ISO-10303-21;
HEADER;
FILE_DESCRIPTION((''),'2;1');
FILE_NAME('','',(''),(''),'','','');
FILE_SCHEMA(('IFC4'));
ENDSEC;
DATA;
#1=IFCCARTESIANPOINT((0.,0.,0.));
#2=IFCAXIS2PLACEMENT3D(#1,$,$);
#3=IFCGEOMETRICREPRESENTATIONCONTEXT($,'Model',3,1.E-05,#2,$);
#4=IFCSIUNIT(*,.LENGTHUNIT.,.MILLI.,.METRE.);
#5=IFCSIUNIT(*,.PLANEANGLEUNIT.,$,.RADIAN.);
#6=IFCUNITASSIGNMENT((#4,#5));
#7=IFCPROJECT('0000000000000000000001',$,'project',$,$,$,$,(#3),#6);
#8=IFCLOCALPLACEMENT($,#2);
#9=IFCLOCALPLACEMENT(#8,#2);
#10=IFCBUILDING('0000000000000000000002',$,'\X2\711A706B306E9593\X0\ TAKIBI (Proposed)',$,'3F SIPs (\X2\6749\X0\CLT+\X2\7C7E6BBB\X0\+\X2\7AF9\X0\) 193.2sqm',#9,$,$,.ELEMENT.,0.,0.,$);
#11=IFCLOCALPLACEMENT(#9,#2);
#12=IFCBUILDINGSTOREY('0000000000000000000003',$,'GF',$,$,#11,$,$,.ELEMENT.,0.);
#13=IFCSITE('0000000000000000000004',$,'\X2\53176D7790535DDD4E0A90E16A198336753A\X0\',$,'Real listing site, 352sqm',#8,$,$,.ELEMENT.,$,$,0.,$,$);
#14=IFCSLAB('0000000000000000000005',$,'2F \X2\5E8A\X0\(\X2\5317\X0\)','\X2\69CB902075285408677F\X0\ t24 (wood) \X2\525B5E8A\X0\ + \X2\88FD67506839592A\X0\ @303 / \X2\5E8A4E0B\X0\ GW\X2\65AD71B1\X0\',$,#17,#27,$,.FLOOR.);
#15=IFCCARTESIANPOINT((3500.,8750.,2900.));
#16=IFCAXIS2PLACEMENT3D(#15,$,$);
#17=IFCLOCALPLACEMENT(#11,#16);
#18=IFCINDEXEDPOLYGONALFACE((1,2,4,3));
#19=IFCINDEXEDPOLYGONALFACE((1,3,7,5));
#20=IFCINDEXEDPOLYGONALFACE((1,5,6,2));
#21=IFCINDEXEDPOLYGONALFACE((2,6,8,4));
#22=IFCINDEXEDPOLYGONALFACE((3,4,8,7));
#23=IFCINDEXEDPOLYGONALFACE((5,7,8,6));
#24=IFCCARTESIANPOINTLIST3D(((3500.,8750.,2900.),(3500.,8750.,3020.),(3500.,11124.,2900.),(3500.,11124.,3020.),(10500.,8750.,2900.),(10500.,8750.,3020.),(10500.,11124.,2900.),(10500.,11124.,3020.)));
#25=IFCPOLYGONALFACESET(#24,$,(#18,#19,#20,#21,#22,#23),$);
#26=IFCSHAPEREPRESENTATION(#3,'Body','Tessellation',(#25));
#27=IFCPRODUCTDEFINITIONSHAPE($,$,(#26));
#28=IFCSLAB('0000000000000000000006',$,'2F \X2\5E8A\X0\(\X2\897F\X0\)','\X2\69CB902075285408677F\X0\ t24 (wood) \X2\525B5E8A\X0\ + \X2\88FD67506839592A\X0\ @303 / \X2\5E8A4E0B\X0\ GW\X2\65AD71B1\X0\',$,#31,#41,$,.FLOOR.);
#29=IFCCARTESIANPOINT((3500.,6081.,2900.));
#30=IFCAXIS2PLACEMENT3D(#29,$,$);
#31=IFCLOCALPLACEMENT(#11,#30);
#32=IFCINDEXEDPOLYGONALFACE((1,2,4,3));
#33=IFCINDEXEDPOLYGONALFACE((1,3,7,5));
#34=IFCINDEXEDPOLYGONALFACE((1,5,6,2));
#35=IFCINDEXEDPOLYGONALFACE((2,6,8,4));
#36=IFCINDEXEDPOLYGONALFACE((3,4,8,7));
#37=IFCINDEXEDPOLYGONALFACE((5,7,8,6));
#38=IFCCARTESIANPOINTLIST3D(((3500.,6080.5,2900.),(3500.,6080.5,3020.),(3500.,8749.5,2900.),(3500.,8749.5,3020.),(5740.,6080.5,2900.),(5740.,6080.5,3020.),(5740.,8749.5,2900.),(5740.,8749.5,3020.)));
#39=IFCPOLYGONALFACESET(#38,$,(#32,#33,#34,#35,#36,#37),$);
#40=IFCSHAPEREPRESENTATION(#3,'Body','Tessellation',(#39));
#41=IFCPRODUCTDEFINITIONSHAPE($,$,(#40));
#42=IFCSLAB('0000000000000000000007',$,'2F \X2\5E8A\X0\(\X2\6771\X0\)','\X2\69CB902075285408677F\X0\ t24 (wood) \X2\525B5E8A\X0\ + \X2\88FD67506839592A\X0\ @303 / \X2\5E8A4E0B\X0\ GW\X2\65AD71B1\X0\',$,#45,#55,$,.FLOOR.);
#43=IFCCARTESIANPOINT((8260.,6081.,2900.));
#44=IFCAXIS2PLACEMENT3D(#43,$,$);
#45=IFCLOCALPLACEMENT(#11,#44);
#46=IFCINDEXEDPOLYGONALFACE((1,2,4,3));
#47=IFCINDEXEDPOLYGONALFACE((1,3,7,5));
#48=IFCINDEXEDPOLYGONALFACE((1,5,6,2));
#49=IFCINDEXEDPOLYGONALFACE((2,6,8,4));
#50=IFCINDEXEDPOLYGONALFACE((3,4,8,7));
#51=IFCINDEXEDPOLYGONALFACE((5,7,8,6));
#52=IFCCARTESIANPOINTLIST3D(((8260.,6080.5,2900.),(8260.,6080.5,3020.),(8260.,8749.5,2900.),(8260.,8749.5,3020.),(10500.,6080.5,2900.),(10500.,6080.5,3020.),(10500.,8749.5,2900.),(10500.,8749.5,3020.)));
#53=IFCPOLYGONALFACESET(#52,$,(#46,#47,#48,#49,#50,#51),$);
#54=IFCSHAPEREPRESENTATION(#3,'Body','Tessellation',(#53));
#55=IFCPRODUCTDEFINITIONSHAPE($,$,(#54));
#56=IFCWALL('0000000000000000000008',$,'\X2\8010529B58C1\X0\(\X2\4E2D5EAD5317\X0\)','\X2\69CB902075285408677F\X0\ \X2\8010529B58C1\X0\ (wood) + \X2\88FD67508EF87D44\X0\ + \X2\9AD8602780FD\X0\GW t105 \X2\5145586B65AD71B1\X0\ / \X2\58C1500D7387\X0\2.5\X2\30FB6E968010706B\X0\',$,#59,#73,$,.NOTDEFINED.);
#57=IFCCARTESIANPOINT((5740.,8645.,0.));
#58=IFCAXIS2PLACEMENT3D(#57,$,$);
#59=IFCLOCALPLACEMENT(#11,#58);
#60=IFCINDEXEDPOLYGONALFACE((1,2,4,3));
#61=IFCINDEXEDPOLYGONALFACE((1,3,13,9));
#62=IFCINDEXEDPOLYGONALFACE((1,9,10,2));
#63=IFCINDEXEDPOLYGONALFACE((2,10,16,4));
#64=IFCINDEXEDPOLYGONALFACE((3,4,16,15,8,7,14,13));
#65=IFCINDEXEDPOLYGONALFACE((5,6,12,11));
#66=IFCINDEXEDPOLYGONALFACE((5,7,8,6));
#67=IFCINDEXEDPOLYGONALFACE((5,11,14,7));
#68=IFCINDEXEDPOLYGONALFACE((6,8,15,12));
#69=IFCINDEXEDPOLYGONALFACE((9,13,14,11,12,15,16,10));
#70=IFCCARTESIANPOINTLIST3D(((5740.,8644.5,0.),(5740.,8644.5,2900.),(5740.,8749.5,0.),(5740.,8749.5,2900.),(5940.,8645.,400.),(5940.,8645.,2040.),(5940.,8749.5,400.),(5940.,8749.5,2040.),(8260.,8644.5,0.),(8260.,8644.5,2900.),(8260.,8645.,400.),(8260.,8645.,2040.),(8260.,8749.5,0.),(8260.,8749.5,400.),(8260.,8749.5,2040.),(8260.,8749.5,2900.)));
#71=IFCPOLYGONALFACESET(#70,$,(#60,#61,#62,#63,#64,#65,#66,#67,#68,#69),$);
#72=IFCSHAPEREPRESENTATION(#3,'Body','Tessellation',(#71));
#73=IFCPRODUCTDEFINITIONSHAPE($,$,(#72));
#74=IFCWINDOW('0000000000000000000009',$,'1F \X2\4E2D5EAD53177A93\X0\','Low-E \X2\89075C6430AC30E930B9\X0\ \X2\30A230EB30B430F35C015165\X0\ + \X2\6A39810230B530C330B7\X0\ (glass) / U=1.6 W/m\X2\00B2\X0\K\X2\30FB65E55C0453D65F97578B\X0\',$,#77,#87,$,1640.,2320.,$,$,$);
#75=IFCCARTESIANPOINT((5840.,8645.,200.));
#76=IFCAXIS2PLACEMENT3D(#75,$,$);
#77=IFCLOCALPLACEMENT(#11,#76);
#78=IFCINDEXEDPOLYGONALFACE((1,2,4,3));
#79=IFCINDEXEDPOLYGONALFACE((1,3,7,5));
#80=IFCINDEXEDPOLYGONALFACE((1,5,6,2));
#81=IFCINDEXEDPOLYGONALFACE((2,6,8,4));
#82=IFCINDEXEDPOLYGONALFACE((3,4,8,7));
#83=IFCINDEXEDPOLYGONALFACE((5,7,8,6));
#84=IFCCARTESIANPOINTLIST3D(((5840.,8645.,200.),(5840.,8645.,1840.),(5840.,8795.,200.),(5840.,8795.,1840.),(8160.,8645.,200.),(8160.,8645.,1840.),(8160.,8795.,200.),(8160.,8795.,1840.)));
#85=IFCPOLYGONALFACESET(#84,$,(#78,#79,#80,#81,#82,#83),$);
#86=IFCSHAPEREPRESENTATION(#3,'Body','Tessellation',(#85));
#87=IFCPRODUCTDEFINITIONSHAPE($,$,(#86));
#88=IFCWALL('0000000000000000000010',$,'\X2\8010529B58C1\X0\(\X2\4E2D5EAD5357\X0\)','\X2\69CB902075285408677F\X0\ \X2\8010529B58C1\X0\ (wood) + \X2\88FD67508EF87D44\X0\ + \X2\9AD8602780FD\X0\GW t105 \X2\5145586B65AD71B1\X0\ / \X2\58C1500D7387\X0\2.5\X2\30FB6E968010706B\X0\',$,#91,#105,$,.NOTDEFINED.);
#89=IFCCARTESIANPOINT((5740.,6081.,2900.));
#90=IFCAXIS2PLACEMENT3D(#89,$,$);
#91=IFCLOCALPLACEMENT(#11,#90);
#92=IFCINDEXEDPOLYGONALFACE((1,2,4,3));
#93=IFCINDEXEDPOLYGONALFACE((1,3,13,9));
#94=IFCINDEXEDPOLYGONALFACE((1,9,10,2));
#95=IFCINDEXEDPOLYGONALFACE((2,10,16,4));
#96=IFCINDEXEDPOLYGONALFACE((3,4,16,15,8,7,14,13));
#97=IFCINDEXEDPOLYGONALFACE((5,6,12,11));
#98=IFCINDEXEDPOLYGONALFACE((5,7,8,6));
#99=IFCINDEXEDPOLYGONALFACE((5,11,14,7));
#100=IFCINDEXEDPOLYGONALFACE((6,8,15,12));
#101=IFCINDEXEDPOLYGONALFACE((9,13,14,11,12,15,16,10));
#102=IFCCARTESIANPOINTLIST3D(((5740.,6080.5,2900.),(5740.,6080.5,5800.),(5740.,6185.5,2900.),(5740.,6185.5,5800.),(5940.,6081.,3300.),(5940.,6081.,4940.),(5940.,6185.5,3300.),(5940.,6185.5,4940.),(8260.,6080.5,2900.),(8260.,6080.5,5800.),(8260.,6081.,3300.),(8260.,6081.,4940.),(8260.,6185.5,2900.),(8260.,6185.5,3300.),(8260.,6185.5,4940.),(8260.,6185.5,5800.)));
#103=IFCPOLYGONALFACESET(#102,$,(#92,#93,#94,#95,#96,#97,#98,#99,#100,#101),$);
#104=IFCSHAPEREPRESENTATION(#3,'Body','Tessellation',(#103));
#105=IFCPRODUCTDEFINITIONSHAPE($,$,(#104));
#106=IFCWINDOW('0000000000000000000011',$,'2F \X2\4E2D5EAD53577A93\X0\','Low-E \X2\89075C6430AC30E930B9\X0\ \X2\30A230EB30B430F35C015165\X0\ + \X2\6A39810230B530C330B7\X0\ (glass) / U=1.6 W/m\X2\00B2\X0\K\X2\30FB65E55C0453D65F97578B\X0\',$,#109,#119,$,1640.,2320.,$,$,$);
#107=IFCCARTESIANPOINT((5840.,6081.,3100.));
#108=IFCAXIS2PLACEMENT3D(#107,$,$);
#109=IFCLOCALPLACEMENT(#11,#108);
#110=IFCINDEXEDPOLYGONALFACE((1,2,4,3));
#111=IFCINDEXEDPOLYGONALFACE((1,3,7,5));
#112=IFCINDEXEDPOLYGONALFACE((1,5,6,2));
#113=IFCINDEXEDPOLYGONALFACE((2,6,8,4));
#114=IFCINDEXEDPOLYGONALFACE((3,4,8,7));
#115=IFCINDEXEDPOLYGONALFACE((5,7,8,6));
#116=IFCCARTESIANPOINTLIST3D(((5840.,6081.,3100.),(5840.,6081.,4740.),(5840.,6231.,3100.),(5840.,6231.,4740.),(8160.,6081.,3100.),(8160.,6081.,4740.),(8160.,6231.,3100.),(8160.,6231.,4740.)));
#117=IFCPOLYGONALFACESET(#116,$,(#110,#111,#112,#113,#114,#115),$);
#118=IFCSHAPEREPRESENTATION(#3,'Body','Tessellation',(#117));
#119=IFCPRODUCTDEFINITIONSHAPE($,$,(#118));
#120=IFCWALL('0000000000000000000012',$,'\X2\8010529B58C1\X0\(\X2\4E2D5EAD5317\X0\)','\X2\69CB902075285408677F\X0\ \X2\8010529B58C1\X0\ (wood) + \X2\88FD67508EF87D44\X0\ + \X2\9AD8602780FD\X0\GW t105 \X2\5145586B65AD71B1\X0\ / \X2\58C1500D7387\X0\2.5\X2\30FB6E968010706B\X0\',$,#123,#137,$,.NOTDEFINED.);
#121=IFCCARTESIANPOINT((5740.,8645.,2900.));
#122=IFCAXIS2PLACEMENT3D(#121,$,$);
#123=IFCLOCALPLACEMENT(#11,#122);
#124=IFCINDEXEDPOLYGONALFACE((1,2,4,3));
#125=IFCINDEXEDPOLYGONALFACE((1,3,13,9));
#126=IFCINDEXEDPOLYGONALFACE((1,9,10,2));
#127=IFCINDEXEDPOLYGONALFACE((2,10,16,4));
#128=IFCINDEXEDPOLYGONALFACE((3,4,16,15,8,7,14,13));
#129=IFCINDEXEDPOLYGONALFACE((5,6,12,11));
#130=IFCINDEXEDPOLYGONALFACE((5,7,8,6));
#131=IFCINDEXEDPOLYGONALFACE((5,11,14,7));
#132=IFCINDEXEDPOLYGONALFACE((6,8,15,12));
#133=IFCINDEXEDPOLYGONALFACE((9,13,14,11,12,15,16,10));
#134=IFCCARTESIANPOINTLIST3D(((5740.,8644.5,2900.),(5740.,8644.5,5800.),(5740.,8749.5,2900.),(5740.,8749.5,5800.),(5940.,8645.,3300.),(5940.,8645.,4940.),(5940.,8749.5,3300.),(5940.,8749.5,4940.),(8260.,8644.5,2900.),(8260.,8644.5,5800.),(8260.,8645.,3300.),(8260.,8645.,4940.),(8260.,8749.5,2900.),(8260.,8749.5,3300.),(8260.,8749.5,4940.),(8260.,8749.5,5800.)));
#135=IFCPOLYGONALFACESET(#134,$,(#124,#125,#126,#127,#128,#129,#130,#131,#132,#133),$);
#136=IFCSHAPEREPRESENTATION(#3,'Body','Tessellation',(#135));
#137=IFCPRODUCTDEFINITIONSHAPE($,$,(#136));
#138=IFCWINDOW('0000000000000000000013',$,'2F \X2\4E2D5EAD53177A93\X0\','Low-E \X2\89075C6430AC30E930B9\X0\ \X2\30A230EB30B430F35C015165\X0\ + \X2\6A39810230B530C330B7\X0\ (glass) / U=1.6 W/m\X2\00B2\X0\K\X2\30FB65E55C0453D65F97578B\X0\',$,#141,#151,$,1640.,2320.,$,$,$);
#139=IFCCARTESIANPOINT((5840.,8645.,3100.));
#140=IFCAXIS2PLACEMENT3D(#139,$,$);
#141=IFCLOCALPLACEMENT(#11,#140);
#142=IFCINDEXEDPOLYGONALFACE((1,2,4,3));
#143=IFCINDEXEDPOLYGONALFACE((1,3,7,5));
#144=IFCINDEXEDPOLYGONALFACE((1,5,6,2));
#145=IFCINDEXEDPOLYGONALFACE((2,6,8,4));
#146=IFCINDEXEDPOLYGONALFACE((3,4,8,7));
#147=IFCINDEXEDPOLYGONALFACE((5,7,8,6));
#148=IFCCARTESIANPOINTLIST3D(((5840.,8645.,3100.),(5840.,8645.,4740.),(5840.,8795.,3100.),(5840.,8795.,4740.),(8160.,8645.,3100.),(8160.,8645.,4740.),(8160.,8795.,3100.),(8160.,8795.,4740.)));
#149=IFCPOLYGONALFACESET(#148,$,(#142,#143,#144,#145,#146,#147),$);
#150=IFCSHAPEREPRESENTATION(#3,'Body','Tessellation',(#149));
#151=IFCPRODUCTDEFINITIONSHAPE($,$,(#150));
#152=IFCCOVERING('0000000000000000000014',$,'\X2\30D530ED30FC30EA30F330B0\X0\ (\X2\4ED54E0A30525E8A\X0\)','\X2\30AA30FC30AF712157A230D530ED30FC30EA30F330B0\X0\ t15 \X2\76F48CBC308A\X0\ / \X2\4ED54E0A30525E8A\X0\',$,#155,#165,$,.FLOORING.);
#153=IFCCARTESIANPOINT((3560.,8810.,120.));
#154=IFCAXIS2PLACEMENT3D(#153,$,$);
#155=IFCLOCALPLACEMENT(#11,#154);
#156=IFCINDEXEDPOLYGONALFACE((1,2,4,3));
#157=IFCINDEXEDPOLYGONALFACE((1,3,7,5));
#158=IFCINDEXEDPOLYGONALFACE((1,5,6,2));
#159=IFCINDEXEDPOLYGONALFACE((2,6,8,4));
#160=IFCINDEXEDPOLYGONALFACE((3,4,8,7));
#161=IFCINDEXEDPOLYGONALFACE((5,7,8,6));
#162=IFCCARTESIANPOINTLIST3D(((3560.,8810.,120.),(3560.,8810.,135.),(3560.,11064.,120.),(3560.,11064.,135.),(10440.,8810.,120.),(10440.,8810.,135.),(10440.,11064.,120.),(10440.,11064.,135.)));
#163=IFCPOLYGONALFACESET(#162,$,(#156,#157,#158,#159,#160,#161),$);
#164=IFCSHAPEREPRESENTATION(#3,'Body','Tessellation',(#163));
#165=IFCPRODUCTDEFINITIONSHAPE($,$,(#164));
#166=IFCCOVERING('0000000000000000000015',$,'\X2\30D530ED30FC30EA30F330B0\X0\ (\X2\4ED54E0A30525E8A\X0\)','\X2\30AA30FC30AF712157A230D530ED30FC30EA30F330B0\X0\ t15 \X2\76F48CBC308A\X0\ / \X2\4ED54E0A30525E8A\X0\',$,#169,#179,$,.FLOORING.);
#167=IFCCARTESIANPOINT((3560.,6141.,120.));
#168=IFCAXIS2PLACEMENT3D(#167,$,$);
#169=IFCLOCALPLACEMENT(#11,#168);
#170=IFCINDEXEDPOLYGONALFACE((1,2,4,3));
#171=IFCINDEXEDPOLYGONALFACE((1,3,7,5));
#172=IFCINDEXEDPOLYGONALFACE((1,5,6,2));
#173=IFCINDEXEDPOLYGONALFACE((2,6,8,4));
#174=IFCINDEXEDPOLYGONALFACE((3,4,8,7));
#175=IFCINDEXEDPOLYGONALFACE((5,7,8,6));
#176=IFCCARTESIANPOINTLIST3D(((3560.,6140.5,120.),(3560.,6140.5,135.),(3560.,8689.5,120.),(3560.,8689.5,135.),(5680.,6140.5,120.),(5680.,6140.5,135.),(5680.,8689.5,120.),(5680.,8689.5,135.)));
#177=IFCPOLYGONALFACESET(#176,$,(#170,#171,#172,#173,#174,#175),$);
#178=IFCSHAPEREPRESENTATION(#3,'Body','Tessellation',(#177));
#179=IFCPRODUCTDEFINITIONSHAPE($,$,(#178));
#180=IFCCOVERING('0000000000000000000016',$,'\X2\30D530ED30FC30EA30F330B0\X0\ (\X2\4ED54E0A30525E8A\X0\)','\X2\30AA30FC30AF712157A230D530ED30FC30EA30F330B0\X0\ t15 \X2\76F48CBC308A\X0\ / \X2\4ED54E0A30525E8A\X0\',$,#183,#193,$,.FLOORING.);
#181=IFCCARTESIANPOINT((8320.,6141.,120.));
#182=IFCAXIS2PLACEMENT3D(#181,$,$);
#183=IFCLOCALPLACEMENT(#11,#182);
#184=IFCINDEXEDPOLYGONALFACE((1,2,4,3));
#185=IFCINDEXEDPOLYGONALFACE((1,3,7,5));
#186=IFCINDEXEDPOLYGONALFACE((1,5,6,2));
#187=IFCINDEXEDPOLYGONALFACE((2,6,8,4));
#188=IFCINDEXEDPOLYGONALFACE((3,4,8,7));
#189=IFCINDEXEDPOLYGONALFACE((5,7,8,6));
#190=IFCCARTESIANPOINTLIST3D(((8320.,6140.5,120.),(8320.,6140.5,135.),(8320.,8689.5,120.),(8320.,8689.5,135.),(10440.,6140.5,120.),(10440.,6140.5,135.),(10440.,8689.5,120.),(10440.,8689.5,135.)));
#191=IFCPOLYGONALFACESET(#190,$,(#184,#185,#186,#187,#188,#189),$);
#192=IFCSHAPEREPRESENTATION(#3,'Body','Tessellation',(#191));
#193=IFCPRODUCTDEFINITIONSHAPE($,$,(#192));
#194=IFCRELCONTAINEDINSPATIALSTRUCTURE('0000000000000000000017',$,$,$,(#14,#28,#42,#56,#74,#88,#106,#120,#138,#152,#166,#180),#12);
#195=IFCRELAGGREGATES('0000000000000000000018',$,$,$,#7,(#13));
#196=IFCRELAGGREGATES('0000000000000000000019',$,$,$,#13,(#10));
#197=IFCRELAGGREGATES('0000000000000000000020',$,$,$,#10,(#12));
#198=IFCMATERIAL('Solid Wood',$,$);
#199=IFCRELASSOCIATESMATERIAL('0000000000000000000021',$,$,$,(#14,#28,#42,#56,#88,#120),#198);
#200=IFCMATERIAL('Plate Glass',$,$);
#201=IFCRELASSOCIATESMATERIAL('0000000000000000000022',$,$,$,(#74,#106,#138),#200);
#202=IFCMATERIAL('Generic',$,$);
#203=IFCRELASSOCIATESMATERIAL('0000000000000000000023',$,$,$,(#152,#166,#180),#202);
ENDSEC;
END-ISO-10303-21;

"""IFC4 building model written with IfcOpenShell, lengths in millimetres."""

from ifc_helpers import new_model, si_unit, frame, frame_2d, origin, place, context, project, spatial, rectangle, extrude, material, element, fill, save


model = new_model("IFC4")

# Units and contexts
model_context = context("Model", 3, precision=1e-05, world=origin())
ifc_project = project(units=[si_unit("LENGTHUNIT", "METRE", prefix="MILLI"), si_unit("PLANEANGLEUNIT", "RADIAN")], contexts=[model_context])

# Site, building, storey
site_placement = place(None, origin())
site = spatial("IfcSite", under=ifc_project, at=site_placement, Name="北海道川上郡標茶町", ObjectType="Real listing site, 352sqm", CompositionType="ELEMENT", RefElevation=0.0)
building_placement = place(site_placement, origin())
building = spatial("IfcBuilding", under=site, at=building_placement, Name="焚火の間 TAKIBI (Proposed)", ObjectType="3F SIPs (杉CLT+籾殻+竹) 193.2sqm", CompositionType="ELEMENT", ElevationOfRefHeight=0.0, ElevationOfTerrain=0.0)
storey_placement = place(building_placement, origin())
storey = spatial("IfcBuildingStorey", under=building, at=storey_placement, Name="GF", CompositionType="ELEMENT", Elevation=0.0)

# Slabs
ifc_material_1 = material(Name="Solid Wood")
slab_1_placement = place(storey_placement, frame((3500.0, 8750.0, 2900.0)))
element("IfcSlab", 1, at=slab_1_placement, inside=storey, material=ifc_material_1, Name="2F 床(北)", Description="構造用合板 t24 (wood) 剛床 + 製材根太 @303 / 床下 GW断熱", PredefinedType="FLOOR", context=model_context, shape_type="SweptSolid", body=[
    extrude(rectangle(XDim=7000.0, YDim=2374.0, at=frame_2d((3500.0, 1187.0))), frame((3500.0, 8750.0, 2900.0)), (0.0, 0.0, 1.0), 120.0),
])
slab_2_placement = place(storey_placement, frame((3500.0, 6081.0, 2900.0)))
element("IfcSlab", 2, at=slab_2_placement, inside=storey, material=ifc_material_1, Name="2F 床(西)", Description="構造用合板 t24 (wood) 剛床 + 製材根太 @303 / 床下 GW断熱", PredefinedType="FLOOR", context=model_context, shape_type="SweptSolid", body=[
    extrude(rectangle(XDim=2240.0, YDim=2669.0, at=frame_2d((1120.0, 1334.0))), frame((3500.0, 6081.0, 2900.0)), (0.0, 0.0, 1.0), 120.0),
])
slab_3_placement = place(storey_placement, frame((8260.0, 6081.0, 2900.0)))
element("IfcSlab", 3, at=slab_3_placement, inside=storey, material=ifc_material_1, Name="2F 床(東)", Description="構造用合板 t24 (wood) 剛床 + 製材根太 @303 / 床下 GW断熱", PredefinedType="FLOOR", context=model_context, shape_type="SweptSolid", body=[
    extrude(rectangle(XDim=2240.0, YDim=2669.0, at=frame_2d((1120.0, 1334.0))), frame((8260.0, 6081.0, 2900.0)), (0.0, 0.0, 1.0), 120.0),
])

# Wall, opening, window
wall_1_placement = place(storey_placement, frame((5740.0, 8645.0, 0.0)))
wall_1 = element("IfcWall", 4, at=wall_1_placement, inside=storey, material=ifc_material_1, Name="耐力壁(中庭北)", Description="構造用合板 耐力壁 (wood) + 製材軸組 + 高性能GW t105 充填断熱 / 壁倍率2.5・準耐火", PredefinedType="NOTDEFINED", context=model_context, shape_type="SweptSolid", body=[
    extrude(rectangle(XDim=2520.0, YDim=105.0, at=frame_2d((1260.0, 52.0))), frame((5740.0, 8645.0, 0.0)), (0.0, 0.0, 1.0), 2900.0),
])
opening_1_placement = place(storey_placement, frame((5840.0, 8645.0, 200.0)))
opening_1 = element("IfcOpeningElement", 5, at=opening_1_placement, cuts=wall_1, PredefinedType="NOTDEFINED", context=model_context, shape_type="SweptSolid", body=[
    extrude(rectangle(XDim=2320.0, YDim=150.0, at=frame_2d((1160.0, 75.0))), frame((5840.0, 8645.0, 200.0)), (0.0, 0.0, 1.0), 1640.0),
])
ifc_material_2 = material(Name="Plate Glass")
window_1_placement = place(storey_placement, frame((5840.0, 8645.0, 200.0)))
window_1 = element("IfcWindow", 6, at=window_1_placement, inside=storey, material=ifc_material_2, Name="1F 中庭北窓", Description="Low-E 複層ガラス アルゴン封入 + 樹脂サッシ (glass) / U=1.6 W/m²K・日射取得型", OverallHeight=1640.0, OverallWidth=2320.0, context=model_context, shape_type="SweptSolid", body=[
    extrude(rectangle(XDim=2320.0, YDim=150.0, at=frame_2d((1160.0, 75.0))), frame((5840.0, 8645.0, 200.0)), (0.0, 0.0, 1.0), 1640.0),
])
fill(opening_1, window_1)

# Walls, openings, windows
wall_2_placement = place(storey_placement, frame((5740.0, 6081.0, 2900.0)))
wall_2 = element("IfcWall", 7, at=wall_2_placement, inside=storey, material=ifc_material_1, Name="耐力壁(中庭南)", Description="構造用合板 耐力壁 (wood) + 製材軸組 + 高性能GW t105 充填断熱 / 壁倍率2.5・準耐火", PredefinedType="NOTDEFINED", context=model_context, shape_type="SweptSolid", body=[
    extrude(rectangle(XDim=2520.0, YDim=105.0, at=frame_2d((1260.0, 52.0))), frame((5740.0, 6081.0, 2900.0)), (0.0, 0.0, 1.0), 2900.0),
])
opening_2_placement = place(storey_placement, frame((5840.0, 6081.0, 3100.0)))
opening_2 = element("IfcOpeningElement", 8, at=opening_2_placement, cuts=wall_2, PredefinedType="NOTDEFINED", context=model_context, shape_type="SweptSolid", body=[
    extrude(rectangle(XDim=2320.0, YDim=150.0, at=frame_2d((1160.0, 75.0))), frame((5840.0, 6081.0, 3100.0)), (0.0, 0.0, 1.0), 1640.0),
])
window_2_placement = place(storey_placement, frame((5840.0, 6081.0, 3100.0)))
window_2 = element("IfcWindow", 9, at=window_2_placement, inside=storey, material=ifc_material_2, Name="2F 中庭南窓", Description="Low-E 複層ガラス アルゴン封入 + 樹脂サッシ (glass) / U=1.6 W/m²K・日射取得型", OverallHeight=1640.0, OverallWidth=2320.0, context=model_context, shape_type="SweptSolid", body=[
    extrude(rectangle(XDim=2320.0, YDim=150.0, at=frame_2d((1160.0, 75.0))), frame((5840.0, 6081.0, 3100.0)), (0.0, 0.0, 1.0), 1640.0),
])
fill(opening_2, window_2)
wall_3_placement = place(storey_placement, frame((5740.0, 8645.0, 2900.0)))
wall_3 = element("IfcWall", 10, at=wall_3_placement, inside=storey, material=ifc_material_1, Name="耐力壁(中庭北)", Description="構造用合板 耐力壁 (wood) + 製材軸組 + 高性能GW t105 充填断熱 / 壁倍率2.5・準耐火", PredefinedType="NOTDEFINED", context=model_context, shape_type="SweptSolid", body=[
    extrude(rectangle(XDim=2520.0, YDim=105.0, at=frame_2d((1260.0, 52.0))), frame((5740.0, 8645.0, 2900.0)), (0.0, 0.0, 1.0), 2900.0),
])
opening_3_placement = place(storey_placement, frame((5840.0, 8645.0, 3100.0)))
opening_3 = element("IfcOpeningElement", 11, at=opening_3_placement, cuts=wall_3, PredefinedType="NOTDEFINED", context=model_context, shape_type="SweptSolid", body=[
    extrude(rectangle(XDim=2320.0, YDim=150.0, at=frame_2d((1160.0, 75.0))), frame((5840.0, 8645.0, 3100.0)), (0.0, 0.0, 1.0), 1640.0),
])
window_3_placement = place(storey_placement, frame((5840.0, 8645.0, 3100.0)))
window_3 = element("IfcWindow", 12, at=window_3_placement, inside=storey, material=ifc_material_2, Name="2F 中庭北窓", Description="Low-E 複層ガラス アルゴン封入 + 樹脂サッシ (glass) / U=1.6 W/m²K・日射取得型", OverallHeight=1640.0, OverallWidth=2320.0, context=model_context, shape_type="SweptSolid", body=[
    extrude(rectangle(XDim=2320.0, YDim=150.0, at=frame_2d((1160.0, 75.0))), frame((5840.0, 8645.0, 3100.0)), (0.0, 0.0, 1.0), 1640.0),
])
fill(opening_3, window_3)

# Coverings
ifc_material_3 = material(Name="Generic")
covering_1_placement = place(storey_placement, frame((3560.0, 8810.0, 120.0)))
element("IfcCovering", 13, at=covering_1_placement, inside=storey, material=ifc_material_3, Name="フローリング (仕上げ床)", Description="オーク無垢フローリング t15 直貼り / 仕上げ床", PredefinedType="FLOORING", context=model_context, shape_type="SweptSolid", body=[
    extrude(rectangle(XDim=6880.0, YDim=2254.0, at=frame_2d((3440.0, 1127.0))), frame((3560.0, 8810.0, 120.0)), (0.0, 0.0, 1.0), 15.0),
])
covering_2_placement = place(storey_placement, frame((3560.0, 6141.0, 120.0)))
element("IfcCovering", 14, at=covering_2_placement, inside=storey, material=ifc_material_3, Name="フローリング (仕上げ床)", Description="オーク無垢フローリング t15 直貼り / 仕上げ床", PredefinedType="FLOORING", context=model_context, shape_type="SweptSolid", body=[
    extrude(rectangle(XDim=2120.0, YDim=2549.0, at=frame_2d((1060.0, 1274.0))), frame((3560.0, 6141.0, 120.0)), (0.0, 0.0, 1.0), 15.0),
])
covering_3_placement = place(storey_placement, frame((8320.0, 6141.0, 120.0)))
element("IfcCovering", 15, at=covering_3_placement, inside=storey, material=ifc_material_3, Name="フローリング (仕上げ床)", Description="オーク無垢フローリング t15 直貼り / 仕上げ床", PredefinedType="FLOORING", context=model_context, shape_type="SweptSolid", body=[
    extrude(rectangle(XDim=2120.0, YDim=2549.0, at=frame_2d((1060.0, 1274.0))), frame((8320.0, 6141.0, 120.0)), (0.0, 0.0, 1.0), 15.0),
])

save(model, "model.ifc")
